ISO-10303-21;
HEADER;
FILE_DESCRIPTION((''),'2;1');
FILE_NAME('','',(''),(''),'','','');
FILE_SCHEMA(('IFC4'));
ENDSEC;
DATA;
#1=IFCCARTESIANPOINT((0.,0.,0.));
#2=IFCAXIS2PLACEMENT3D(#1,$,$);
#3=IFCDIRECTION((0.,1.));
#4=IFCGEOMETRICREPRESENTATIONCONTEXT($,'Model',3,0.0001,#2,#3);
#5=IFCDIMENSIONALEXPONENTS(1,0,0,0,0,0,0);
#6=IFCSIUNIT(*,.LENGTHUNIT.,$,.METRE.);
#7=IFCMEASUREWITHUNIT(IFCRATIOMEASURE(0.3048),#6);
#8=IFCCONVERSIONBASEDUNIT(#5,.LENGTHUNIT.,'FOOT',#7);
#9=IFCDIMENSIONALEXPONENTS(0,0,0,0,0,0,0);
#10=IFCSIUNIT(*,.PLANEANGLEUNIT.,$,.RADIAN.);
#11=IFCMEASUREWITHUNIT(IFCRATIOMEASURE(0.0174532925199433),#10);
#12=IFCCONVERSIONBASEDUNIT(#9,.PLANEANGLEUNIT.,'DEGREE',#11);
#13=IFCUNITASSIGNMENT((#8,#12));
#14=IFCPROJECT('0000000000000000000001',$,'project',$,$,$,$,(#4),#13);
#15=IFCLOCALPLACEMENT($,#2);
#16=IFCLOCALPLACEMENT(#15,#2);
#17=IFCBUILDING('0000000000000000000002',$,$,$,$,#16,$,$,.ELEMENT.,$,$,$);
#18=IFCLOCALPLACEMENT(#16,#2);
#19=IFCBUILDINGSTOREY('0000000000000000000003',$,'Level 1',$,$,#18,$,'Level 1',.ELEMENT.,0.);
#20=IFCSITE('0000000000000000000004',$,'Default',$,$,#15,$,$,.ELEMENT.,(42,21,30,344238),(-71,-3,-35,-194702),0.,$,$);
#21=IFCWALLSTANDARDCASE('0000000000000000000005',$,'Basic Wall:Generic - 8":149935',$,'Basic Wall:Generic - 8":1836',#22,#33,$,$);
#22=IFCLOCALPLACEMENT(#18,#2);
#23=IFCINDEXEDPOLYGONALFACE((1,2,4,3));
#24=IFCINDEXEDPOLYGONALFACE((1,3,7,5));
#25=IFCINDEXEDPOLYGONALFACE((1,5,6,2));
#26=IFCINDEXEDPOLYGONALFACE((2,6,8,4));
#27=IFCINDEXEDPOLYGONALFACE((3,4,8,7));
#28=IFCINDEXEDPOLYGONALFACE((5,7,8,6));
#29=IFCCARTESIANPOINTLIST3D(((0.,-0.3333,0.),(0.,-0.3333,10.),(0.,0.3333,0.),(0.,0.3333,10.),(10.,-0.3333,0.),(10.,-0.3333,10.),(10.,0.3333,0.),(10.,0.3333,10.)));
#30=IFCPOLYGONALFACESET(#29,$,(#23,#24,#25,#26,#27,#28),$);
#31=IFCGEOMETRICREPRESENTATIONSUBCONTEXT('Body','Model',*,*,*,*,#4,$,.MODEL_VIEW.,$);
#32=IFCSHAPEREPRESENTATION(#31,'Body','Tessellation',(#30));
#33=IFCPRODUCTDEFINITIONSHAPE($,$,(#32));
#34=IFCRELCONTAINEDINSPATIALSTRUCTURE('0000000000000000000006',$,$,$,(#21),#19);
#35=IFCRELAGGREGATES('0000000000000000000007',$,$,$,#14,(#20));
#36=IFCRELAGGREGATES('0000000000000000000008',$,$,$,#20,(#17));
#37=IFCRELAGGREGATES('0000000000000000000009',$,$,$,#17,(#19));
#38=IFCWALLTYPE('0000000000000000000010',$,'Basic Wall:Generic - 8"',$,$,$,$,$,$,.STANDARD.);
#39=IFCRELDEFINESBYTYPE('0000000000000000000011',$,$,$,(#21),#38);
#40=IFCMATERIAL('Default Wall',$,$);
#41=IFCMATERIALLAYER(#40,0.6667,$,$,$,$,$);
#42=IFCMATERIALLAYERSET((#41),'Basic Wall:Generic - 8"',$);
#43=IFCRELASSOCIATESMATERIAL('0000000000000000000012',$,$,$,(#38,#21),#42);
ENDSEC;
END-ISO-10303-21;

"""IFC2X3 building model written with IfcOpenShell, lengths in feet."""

from ifc_helpers import new_model, entity, si_unit, converted_unit, direction, frame_2d, origin, place, context, subcontext, project, spatial, rectangle, extrude, material, layer, layer_set, layer_usage, type_object, element, save


model = new_model("IFC2X3")

# Units and contexts
model_context = context("Model", 3, precision=0.0001, world=origin(), true_north=direction((0.0, 1.0)))
body_context = subcontext(model_context, "Body", "Model", "MODEL_VIEW")
ifc_project = project(units=[converted_unit("LENGTHUNIT", "FOOT", entity("IfcRatioMeasure", 0.3048), si_unit("LENGTHUNIT", "METRE"), dimensions=[1, 0, 0, 0, 0, 0, 0]), converted_unit("PLANEANGLEUNIT", "DEGREE", entity("IfcRatioMeasure", 0.0174532925199433), si_unit("PLANEANGLEUNIT", "RADIAN"), dimensions=[0, 0, 0, 0, 0, 0, 0])], contexts=[model_context])

# Site, building, storey
site_placement = place(None, origin())
site = spatial("IfcSite", under=ifc_project, at=site_placement, Name="Default", CompositionType="ELEMENT", RefLatitude=(42, 21, 30, 344238), RefLongitude=(-71, -3, -35, -194702), RefElevation=0.0)
building_placement = place(site_placement, origin())
building = spatial("IfcBuilding", under=site, at=building_placement, CompositionType="ELEMENT")
storey_placement = place(building_placement, origin())
storey = spatial("IfcBuildingStorey", under=building, at=storey_placement, Name="Level 1", LongName="Level 1", CompositionType="ELEMENT", Elevation=0.0)

# Wall
ifc_material = material(Name="Default Wall")
ifc_layer = layer(ifc_material, 0.6667)
ifc_layer_set = layer_set([ifc_layer], Name="Basic Wall:Generic - 8\"")
ifc_layer_usage = layer_usage(ifc_layer_set, "AXIS2", "NEGATIVE", 0.3333)
wall_type = type_object("IfcWallType", Name="Basic Wall:Generic - 8\"", PredefinedType="STANDARD", material=ifc_layer_set)
wall_placement = place(storey_placement, origin())
element("IfcWallStandardCase", 1, at=wall_placement, inside=storey, type_object=wall_type, material=ifc_layer_usage, Name="Basic Wall:Generic - 8\":149935", ObjectType="Basic Wall:Generic - 8\":1836", context=body_context, shape_type="SweptSolid", body=[
    extrude(rectangle(XDim=10.0, YDim=0.6667, at=frame_2d((5.0, 0.0), x_axis=(-1.0, 0.0))), origin(), (0.0, 0.0, 1.0), 10.0),
])

save(model, "model.ifc")
